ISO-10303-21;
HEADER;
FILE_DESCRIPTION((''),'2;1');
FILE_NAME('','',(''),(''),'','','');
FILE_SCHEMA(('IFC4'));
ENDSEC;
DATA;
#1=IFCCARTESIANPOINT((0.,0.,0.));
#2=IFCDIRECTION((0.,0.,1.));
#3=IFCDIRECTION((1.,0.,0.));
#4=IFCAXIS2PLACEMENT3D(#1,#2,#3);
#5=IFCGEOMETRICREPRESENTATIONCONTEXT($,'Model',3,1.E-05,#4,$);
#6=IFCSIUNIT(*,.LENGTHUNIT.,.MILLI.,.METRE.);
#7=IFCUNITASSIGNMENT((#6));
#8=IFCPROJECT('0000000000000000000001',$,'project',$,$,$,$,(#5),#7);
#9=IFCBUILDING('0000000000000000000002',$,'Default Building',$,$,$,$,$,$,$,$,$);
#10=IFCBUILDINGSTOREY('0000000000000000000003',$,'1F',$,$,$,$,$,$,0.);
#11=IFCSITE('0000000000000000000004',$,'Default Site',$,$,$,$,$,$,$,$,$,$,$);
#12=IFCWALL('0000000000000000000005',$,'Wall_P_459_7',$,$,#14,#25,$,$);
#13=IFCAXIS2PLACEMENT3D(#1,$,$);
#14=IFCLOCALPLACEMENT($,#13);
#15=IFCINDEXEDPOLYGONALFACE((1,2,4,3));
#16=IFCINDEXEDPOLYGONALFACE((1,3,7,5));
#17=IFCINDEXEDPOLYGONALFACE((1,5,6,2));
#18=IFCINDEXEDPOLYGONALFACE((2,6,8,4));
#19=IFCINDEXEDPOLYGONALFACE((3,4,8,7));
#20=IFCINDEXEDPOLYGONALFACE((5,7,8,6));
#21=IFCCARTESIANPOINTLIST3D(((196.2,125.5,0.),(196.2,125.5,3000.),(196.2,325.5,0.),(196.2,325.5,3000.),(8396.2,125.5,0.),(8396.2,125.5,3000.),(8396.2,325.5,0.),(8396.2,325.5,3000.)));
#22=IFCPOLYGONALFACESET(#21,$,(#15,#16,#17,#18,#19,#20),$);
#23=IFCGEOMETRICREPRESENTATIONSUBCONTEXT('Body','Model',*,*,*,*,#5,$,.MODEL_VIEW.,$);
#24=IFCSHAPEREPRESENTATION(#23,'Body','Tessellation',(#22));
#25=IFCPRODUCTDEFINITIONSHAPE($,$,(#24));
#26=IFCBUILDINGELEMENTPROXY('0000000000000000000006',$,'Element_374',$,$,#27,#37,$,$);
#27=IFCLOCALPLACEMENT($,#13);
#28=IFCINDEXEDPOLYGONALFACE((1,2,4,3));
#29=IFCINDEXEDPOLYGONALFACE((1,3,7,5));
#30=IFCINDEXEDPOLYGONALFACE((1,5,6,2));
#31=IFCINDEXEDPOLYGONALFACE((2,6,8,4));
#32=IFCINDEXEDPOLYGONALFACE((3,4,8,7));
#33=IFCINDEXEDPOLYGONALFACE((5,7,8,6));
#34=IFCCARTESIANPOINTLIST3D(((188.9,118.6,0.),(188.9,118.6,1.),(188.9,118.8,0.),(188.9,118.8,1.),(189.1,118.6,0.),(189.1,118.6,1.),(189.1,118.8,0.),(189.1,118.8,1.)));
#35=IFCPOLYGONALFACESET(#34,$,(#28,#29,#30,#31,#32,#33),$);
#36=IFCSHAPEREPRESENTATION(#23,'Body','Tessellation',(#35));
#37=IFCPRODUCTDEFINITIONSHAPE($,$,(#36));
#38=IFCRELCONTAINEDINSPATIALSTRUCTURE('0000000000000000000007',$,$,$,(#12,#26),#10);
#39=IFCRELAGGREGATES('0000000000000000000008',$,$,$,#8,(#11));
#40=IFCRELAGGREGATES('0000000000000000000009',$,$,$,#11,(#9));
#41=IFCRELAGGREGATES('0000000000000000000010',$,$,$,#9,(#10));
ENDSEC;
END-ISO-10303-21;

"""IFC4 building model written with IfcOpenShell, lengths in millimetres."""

from ifc_helpers import new_model, si_unit, frame, origin, origin_with_axes, place, context, subcontext, project, spatial, polyline, indexed_curve, outline, extrude, element, save


model = new_model("IFC4")

# Units and contexts
model_context = context("Model", 3, precision=1e-05, world=origin_with_axes())
body_context = subcontext(model_context, "Body", "Model", "MODEL_VIEW")
ifc_project = project(units=[si_unit("LENGTHUNIT", "METRE", prefix="MILLI")], contexts=[model_context])

# Site, building, storey
site = spatial("IfcSite", under=ifc_project, Name="Default Site")
building = spatial("IfcBuilding", under=site, Name="Default Building")
storey = spatial("IfcBuildingStorey", under=building, Name="1F", Elevation=0.0)

# Wall
wall_1_placement = place(None, frame((196.2, 125.5, 0.0), z_axis=(0.0, 0.0, 1.0), x_axis=(1.0, 0.0, 0.0)))
element("IfcWall", 1, at=wall_1_placement, inside=storey, Name="Wall_P_459_7", context=body_context, shape_type="SweptSolid", body=[
    extrude(outline(indexed_curve([(0.0, 0.0), (0.0, 200.0), (8200.0, 200.0), (8200.0, 0.0), (0.0, 0.0)], self_intersect=False)), origin_with_axes(), (0.0, 0.0, 1.0), 3000.0),
])

# Building element proxy
proxy_1_placement = place(None, frame((189.0, 118.7, 0.0), z_axis=(0.0, 0.0, 1.0), x_axis=(1.0, 0.0, 0.0)))
element("IfcBuildingElementProxy", 2, at=proxy_1_placement, inside=storey, Name="Element_374", context=body_context, shape_type="SweptSolid", body=[
    extrude(outline(polyline([(0.1, -0.1), (-0.1, -0.1), (-0.1, 0.1), (0.1, 0.1), (0.1, -0.1)])), origin(), (0.0, 0.0, 1.0), 1.0),
])

save(model, "model.ifc")
